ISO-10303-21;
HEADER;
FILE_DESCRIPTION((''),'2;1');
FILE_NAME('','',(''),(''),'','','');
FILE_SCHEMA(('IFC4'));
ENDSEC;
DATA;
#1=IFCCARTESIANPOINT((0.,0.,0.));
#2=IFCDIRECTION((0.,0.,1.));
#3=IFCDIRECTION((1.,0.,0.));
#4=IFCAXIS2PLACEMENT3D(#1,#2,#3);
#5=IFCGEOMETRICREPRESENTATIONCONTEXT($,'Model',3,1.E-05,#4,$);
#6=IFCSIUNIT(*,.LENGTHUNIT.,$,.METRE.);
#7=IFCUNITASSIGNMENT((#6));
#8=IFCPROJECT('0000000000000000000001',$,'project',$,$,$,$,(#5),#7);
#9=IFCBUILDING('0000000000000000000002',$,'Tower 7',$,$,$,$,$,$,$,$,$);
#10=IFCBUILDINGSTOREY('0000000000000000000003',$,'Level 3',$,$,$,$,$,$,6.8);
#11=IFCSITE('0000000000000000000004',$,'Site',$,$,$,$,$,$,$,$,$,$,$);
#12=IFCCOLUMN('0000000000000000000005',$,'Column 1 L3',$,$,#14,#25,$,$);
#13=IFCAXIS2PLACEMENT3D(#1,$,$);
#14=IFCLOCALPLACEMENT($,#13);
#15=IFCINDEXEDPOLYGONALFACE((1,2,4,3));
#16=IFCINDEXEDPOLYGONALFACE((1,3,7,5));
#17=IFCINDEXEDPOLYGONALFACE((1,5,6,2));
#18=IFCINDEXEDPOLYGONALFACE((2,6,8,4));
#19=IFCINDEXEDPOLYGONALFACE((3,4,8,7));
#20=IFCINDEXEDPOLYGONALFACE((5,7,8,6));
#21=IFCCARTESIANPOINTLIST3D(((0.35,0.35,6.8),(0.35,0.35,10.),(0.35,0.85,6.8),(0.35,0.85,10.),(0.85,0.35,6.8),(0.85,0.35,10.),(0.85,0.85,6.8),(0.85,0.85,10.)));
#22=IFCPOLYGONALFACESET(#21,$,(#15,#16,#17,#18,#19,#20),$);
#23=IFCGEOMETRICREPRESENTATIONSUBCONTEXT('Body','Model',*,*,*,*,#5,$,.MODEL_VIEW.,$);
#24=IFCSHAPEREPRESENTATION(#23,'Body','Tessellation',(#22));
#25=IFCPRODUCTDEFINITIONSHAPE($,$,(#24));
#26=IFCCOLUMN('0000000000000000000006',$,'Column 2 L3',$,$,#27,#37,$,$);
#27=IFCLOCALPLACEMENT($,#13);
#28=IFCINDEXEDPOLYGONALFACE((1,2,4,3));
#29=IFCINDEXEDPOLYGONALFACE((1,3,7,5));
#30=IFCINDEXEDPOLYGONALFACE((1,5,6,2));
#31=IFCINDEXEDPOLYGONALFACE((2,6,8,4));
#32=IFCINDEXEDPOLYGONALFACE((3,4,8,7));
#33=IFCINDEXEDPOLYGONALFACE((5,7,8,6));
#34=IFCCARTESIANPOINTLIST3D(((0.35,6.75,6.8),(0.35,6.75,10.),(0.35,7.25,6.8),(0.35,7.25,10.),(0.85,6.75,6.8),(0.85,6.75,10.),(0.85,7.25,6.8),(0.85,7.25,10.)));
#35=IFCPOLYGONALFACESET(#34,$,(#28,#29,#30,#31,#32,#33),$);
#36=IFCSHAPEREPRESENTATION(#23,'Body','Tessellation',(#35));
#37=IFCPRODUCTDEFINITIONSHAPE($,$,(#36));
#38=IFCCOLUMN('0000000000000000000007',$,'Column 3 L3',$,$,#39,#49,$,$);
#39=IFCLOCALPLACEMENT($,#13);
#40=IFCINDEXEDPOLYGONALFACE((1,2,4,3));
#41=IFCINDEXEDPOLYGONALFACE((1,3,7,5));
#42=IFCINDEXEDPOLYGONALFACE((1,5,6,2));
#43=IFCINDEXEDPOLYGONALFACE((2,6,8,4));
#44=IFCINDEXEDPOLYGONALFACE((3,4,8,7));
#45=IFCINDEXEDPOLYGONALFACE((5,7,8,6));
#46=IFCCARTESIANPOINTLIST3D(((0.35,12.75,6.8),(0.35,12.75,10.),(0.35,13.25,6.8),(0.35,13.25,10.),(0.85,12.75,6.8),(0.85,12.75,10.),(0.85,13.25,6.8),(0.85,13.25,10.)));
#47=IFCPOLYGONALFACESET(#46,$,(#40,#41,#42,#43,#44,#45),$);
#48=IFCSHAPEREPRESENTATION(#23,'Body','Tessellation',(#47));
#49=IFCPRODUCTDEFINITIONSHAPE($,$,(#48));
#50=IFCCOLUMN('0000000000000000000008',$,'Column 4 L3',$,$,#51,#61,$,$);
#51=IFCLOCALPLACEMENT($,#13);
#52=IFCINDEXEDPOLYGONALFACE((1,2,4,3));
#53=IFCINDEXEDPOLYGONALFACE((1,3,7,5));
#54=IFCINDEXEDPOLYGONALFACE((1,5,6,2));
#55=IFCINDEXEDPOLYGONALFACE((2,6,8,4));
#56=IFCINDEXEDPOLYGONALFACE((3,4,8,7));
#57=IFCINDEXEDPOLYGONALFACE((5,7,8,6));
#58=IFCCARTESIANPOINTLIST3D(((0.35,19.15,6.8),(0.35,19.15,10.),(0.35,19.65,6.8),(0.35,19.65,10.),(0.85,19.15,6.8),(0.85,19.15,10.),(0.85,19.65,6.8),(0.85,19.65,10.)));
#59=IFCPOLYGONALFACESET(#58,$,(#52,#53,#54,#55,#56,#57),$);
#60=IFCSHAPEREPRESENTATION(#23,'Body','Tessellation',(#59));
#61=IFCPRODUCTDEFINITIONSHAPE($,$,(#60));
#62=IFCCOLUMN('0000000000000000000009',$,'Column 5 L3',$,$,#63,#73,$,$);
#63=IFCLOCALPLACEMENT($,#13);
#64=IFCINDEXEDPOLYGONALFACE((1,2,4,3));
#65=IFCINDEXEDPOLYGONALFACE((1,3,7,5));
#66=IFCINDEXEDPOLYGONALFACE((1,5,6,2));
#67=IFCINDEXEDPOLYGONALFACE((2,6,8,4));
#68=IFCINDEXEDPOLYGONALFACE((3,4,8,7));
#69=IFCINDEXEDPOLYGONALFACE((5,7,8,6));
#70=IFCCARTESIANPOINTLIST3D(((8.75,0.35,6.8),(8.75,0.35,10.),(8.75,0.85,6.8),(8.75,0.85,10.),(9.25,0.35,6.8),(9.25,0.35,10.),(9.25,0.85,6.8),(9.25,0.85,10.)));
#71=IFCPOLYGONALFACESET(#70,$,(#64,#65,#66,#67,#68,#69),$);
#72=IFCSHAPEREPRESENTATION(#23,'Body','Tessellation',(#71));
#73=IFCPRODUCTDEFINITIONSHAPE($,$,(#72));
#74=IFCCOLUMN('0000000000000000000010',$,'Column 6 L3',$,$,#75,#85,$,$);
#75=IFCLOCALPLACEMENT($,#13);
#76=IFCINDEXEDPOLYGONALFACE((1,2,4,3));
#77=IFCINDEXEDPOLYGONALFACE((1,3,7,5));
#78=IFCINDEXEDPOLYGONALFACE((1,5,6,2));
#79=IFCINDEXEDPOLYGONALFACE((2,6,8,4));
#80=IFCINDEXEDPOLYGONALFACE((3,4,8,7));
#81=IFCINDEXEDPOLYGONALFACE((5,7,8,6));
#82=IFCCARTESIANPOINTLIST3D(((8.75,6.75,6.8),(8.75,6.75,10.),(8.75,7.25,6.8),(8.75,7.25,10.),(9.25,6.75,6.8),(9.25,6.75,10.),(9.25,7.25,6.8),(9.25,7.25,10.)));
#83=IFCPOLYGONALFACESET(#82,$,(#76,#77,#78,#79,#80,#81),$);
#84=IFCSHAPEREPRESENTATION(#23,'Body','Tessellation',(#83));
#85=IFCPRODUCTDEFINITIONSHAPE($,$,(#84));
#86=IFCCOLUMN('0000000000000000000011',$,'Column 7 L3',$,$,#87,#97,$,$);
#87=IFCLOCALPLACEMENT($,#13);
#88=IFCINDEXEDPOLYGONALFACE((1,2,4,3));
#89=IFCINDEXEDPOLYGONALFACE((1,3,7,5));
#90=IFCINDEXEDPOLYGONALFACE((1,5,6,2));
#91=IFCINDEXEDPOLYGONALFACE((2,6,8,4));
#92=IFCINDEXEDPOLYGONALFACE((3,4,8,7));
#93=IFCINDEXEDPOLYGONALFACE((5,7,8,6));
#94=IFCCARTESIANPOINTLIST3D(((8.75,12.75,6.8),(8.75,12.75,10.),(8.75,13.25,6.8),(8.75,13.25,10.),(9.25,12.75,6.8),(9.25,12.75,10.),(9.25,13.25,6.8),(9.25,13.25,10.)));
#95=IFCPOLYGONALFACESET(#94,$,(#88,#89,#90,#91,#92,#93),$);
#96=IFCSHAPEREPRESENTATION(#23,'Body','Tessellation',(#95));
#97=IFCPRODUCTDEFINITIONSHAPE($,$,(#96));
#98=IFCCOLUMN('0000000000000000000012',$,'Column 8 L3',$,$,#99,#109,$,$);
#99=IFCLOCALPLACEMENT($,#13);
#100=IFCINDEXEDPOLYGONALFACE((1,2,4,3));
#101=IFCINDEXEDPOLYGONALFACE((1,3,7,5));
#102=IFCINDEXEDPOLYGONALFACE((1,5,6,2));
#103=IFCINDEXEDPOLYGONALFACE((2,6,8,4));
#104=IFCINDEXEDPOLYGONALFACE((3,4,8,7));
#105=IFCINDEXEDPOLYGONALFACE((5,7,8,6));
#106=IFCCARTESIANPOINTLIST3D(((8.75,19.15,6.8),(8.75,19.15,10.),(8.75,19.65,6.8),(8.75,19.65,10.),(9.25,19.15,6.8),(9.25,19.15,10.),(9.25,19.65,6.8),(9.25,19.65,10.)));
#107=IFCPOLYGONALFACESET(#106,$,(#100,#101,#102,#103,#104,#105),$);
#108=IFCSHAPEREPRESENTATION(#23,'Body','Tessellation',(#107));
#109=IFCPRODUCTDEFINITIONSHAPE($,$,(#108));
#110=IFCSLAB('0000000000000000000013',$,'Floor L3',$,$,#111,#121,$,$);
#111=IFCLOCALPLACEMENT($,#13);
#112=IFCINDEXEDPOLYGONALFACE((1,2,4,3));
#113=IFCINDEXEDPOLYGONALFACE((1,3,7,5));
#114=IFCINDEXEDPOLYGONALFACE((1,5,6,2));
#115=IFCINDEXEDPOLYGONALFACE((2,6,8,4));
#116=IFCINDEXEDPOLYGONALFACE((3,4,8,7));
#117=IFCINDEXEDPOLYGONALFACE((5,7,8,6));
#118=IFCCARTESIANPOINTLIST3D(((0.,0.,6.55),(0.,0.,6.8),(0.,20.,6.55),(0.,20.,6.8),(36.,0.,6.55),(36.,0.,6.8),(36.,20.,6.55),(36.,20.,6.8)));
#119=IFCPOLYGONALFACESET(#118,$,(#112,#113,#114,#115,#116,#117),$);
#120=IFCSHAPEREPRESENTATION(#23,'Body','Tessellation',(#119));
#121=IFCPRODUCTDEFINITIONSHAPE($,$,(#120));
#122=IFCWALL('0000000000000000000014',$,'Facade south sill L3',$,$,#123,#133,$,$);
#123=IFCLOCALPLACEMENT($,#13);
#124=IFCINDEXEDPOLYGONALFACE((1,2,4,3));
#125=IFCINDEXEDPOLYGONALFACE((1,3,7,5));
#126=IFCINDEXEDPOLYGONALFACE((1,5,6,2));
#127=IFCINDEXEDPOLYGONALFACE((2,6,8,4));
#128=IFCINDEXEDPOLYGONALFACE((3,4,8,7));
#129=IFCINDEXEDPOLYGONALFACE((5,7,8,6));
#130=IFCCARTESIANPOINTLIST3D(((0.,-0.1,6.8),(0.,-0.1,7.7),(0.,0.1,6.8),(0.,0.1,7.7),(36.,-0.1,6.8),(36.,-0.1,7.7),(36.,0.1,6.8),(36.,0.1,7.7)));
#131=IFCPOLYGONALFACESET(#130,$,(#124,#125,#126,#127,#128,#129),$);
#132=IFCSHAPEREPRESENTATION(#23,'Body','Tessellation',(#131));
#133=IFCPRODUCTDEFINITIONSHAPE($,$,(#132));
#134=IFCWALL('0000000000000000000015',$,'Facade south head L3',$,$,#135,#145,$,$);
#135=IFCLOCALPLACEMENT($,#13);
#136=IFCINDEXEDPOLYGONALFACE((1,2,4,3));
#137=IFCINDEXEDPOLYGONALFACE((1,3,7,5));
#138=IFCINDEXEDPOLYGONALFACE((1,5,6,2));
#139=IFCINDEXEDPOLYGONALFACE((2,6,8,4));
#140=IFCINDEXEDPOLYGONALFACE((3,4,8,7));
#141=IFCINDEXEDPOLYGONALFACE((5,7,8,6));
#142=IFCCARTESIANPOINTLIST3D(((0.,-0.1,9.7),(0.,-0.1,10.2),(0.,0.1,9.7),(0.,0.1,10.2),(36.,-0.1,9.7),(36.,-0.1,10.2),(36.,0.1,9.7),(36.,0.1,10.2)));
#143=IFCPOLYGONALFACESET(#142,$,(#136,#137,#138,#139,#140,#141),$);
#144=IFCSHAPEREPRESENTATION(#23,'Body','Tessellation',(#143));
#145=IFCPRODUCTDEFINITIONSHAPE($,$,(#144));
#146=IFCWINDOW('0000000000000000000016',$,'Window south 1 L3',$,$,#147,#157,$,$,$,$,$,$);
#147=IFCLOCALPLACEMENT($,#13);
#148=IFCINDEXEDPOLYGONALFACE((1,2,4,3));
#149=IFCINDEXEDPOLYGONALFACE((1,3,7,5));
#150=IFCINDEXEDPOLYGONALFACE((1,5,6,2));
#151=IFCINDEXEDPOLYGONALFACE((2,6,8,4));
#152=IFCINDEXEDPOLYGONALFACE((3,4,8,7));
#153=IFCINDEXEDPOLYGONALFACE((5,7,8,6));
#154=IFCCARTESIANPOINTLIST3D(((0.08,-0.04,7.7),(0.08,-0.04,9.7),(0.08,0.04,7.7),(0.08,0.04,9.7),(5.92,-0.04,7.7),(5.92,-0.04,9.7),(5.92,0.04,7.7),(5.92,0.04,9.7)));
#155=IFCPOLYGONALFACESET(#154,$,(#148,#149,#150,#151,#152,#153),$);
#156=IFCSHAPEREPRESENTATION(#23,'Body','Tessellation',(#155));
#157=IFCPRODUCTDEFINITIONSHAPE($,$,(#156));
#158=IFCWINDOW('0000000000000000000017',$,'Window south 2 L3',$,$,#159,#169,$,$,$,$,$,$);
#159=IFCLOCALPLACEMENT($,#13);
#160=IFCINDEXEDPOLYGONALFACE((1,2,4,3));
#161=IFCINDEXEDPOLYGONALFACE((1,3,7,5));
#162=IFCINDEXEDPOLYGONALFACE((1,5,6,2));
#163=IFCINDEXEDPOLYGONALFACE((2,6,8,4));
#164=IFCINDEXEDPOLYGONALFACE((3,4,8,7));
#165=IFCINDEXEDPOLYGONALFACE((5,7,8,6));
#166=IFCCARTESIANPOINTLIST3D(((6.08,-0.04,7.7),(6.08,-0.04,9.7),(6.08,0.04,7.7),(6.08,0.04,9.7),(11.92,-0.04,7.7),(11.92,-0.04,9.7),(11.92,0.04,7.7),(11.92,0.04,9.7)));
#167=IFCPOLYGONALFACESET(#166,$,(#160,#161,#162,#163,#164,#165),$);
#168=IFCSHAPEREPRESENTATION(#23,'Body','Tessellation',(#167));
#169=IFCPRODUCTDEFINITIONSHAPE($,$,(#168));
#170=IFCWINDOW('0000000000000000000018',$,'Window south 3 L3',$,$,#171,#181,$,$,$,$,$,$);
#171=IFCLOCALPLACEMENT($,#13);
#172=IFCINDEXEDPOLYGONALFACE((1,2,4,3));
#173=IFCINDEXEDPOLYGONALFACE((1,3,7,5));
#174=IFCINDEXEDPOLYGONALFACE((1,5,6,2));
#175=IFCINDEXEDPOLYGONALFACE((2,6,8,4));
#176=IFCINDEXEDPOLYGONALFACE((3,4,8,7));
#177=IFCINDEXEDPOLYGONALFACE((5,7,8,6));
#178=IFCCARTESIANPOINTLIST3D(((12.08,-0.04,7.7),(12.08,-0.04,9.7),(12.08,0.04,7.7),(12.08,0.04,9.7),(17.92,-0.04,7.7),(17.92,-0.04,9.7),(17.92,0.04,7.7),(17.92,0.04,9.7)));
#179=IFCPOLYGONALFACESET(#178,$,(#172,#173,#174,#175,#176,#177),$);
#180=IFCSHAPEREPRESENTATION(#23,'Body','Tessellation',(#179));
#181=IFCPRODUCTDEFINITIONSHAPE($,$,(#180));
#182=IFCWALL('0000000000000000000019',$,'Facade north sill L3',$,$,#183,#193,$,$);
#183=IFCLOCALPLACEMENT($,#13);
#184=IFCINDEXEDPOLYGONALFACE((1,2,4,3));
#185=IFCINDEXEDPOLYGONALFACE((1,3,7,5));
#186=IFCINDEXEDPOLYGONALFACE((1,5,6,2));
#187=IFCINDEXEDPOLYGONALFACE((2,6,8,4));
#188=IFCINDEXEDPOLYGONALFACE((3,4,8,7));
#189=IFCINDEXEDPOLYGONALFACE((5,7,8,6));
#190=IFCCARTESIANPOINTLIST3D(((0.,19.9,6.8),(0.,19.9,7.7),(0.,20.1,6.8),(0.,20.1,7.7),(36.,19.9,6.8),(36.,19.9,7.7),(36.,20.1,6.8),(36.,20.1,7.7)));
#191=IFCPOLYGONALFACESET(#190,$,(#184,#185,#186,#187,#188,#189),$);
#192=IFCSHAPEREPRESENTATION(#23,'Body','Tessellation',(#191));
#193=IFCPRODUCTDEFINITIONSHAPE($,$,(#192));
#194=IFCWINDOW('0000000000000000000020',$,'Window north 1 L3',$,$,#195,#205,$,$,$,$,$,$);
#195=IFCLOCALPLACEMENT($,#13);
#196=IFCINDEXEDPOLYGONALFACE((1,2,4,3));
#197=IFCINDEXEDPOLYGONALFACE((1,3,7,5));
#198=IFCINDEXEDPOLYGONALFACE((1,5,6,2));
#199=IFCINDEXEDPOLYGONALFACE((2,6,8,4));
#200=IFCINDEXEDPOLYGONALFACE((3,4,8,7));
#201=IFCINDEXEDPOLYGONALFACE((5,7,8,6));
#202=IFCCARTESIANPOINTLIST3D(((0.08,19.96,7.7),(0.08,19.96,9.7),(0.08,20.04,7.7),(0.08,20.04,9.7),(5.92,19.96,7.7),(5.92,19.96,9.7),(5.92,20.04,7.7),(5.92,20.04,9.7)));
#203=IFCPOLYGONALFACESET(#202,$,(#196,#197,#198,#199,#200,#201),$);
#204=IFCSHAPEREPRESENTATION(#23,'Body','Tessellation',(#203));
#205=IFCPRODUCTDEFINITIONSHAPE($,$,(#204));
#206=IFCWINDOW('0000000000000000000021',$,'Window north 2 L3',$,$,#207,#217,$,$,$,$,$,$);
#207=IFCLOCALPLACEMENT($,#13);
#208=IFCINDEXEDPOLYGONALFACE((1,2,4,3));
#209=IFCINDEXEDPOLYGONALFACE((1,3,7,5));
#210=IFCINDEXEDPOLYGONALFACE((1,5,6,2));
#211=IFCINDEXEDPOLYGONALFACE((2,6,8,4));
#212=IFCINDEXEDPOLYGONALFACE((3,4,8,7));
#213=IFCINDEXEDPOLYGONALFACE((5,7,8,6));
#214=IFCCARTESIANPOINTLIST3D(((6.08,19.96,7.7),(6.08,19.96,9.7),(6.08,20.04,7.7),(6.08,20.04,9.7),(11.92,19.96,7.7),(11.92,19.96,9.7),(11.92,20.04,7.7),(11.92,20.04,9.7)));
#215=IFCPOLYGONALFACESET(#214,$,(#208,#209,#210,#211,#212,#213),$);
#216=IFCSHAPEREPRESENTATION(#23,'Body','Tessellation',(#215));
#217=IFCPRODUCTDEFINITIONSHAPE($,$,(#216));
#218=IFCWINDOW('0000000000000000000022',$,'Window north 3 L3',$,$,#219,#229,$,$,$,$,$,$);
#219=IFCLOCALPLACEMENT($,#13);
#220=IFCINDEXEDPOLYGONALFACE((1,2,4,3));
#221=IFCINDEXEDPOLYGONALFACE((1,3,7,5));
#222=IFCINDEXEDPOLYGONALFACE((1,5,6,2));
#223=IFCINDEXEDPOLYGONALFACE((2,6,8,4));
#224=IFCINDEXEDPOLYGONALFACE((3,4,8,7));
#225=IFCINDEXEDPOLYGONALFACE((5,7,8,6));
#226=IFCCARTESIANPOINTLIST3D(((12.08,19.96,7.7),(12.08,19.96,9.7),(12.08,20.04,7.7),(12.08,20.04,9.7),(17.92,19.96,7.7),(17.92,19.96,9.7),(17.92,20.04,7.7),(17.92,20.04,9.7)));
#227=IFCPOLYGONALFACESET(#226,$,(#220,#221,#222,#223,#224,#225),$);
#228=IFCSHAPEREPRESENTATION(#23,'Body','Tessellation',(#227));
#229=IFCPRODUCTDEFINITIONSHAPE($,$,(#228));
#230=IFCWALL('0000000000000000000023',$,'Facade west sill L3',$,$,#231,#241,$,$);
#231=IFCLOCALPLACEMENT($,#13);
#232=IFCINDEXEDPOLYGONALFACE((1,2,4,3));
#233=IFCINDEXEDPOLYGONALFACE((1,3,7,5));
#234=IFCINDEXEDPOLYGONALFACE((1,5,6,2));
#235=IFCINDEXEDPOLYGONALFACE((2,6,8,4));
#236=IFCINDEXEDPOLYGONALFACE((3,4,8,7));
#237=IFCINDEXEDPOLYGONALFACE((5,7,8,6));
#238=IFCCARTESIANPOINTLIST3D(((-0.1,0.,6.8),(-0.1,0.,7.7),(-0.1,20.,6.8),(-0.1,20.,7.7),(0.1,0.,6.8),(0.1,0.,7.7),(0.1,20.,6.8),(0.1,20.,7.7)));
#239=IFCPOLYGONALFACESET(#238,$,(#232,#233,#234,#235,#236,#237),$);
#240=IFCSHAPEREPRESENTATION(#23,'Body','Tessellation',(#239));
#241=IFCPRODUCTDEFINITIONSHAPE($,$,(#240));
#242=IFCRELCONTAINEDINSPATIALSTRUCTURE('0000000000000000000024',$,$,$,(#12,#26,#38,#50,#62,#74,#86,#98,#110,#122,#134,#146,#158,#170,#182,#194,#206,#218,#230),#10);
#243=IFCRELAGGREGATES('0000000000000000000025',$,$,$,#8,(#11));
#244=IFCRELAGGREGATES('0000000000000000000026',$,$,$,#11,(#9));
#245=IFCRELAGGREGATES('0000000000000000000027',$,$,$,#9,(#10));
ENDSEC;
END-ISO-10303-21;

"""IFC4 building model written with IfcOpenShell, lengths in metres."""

from ifc_helpers import new_model, si_unit, frame, origin, origin_with_axes, origin_2d, place, context, subcontext, project, spatial, rectangle, extrude, element, save


model = new_model("IFC4")

# Units and contexts
model_context = context("Model", 3, precision=1e-05, world=origin_with_axes())
body_context = subcontext(model_context, "Body", "Model", "MODEL_VIEW")
ifc_project = project(units=[si_unit("LENGTHUNIT", "METRE")], contexts=[model_context])

# Site, building, storey
site = spatial("IfcSite", under=ifc_project, Name="Site")
building = spatial("IfcBuilding", under=site, Name="Tower 7")
storey = spatial("IfcBuildingStorey", under=building, Name="Level 3", Elevation=6.8)

# Columns
for number, where, z_axis, x_axis, name in (
    (1, (0.6, 0.6, 6.8), (0.0, 0.0, 1.0), (1.0, 0.0, 0.0), "Column 1 L3"),
    (2, (0.6, 7.0, 6.8), (0.0, 0.0, 1.0), (1.0, 0.0, 0.0), "Column 2 L3"),
    (3, (0.6, 13.0, 6.8), (0.0, 0.0, 1.0), (1.0, 0.0, 0.0), "Column 3 L3"),
    (4, (0.6, 19.4, 6.8), (0.0, 0.0, 1.0), (1.0, 0.0, 0.0), "Column 4 L3"),
    (5, (9.0, 0.6, 6.8), (0.0, 0.0, 1.0), (1.0, 0.0, 0.0), "Column 5 L3"),
    (6, (9.0, 7.0, 6.8), (0.0, 0.0, 1.0), (1.0, 0.0, 0.0), "Column 6 L3"),
    (7, (9.0, 13.0, 6.8), (0.0, 0.0, 1.0), (1.0, 0.0, 0.0), "Column 7 L3"),
    (8, (9.0, 19.4, 6.8), (0.0, 0.0, 1.0), (1.0, 0.0, 0.0), "Column 8 L3"),
):
    element("IfcColumn", number, at=place(None, frame(where, z_axis=z_axis, x_axis=x_axis)), inside=storey, Name=name, context=body_context, shape_type="SweptSolid", body=[
        extrude(rectangle(XDim=0.5, YDim=0.5, at=origin_2d()), origin(), (0.0, 0.0, 1.0), 3.2),
    ])

# Slab
slab_placement = place(None, frame((18.0, 10.0, 6.55), z_axis=(0.0, 0.0, 1.0), x_axis=(1.0, 0.0, 0.0)))
element("IfcSlab", 9, at=slab_placement, inside=storey, Name="Floor L3", context=body_context, shape_type="SweptSolid", body=[
    extrude(rectangle(XDim=36.0, YDim=20.0, at=origin_2d()), origin(), (0.0, 0.0, 1.0), 0.25),
])

# Walls
wall_1_placement = place(None, frame((18.0, 0.0, 6.8), z_axis=(0.0, 0.0, 1.0), x_axis=(1.0, 0.0, 0.0)))
element("IfcWall", 10, at=wall_1_placement, inside=storey, Name="Facade south sill L3", context=body_context, shape_type="SweptSolid", body=[
    extrude(rectangle(XDim=36.0, YDim=0.2, at=origin_2d()), origin(), (0.0, 0.0, 1.0), 0.9),
])
wall_2_placement = place(None, frame((18.0, 0.0, 9.7), z_axis=(0.0, 0.0, 1.0), x_axis=(1.0, 0.0, 0.0)))
element("IfcWall", 11, at=wall_2_placement, inside=storey, Name="Facade south head L3", context=body_context, shape_type="SweptSolid", body=[
    extrude(rectangle(XDim=36.0, YDim=0.2, at=origin_2d()), origin(), (0.0, 0.0, 1.0), 0.5),
])

# Windows
for number, where, z_axis, x_axis, name in (
    (12, (3.0, 0.0, 7.7), (0.0, 0.0, 1.0), (1.0, 0.0, 0.0), "Window south 1 L3"),
    (13, (9.0, 0.0, 7.7), (0.0, 0.0, 1.0), (1.0, 0.0, 0.0), "Window south 2 L3"),
):
    element("IfcWindow", number, at=place(None, frame(where, z_axis=z_axis, x_axis=x_axis)), inside=storey, Name=name, context=body_context, shape_type="SweptSolid", body=[
        extrude(rectangle(XDim=5.84, YDim=0.08, at=origin_2d()), origin(), (0.0, 0.0, 1.0), 2.0),
    ])
window_1_placement = place(None, frame((15.0, 0.0, 7.7), z_axis=(0.0, 0.0, 1.0), x_axis=(1.0, 0.0, 0.0)))
element("IfcWindow", 14, at=window_1_placement, inside=storey, Name="Window south 3 L3", context=body_context, shape_type="SweptSolid", body=[
    extrude(rectangle(XDim=5.84, YDim=0.08, at=origin_2d()), origin(), (0.0, 0.0, 1.0), 2.0),
])

# Wall
wall_3_placement = place(None, frame((18.0, 20.0, 6.8), z_axis=(0.0, 0.0, 1.0), x_axis=(1.0, 0.0, 0.0)))
element("IfcWall", 15, at=wall_3_placement, inside=storey, Name="Facade north sill L3", context=body_context, shape_type="SweptSolid", body=[
    extrude(rectangle(XDim=36.0, YDim=0.2, at=origin_2d()), origin(), (0.0, 0.0, 1.0), 0.9),
])

# Windows
for number, where, z_axis, x_axis, name in (
    (16, (3.0, 20.0, 7.7), (0.0, 0.0, 1.0), (1.0, 0.0, 0.0), "Window north 1 L3"),
    (17, (9.0, 20.0, 7.7), (0.0, 0.0, 1.0), (1.0, 0.0, 0.0), "Window north 2 L3"),
):
    element("IfcWindow", number, at=place(None, frame(where, z_axis=z_axis, x_axis=x_axis)), inside=storey, Name=name, context=body_context, shape_type="SweptSolid", body=[
        extrude(rectangle(XDim=5.84, YDim=0.08, at=origin_2d()), origin(), (0.0, 0.0, 1.0), 2.0),
    ])
window_2_placement = place(None, frame((15.0, 20.0, 7.7), z_axis=(0.0, 0.0, 1.0), x_axis=(1.0, 0.0, 0.0)))
element("IfcWindow", 18, at=window_2_placement, inside=storey, Name="Window north 3 L3", context=body_context, shape_type="SweptSolid", body=[
    extrude(rectangle(XDim=5.84, YDim=0.08, at=origin_2d()), origin(), (0.0, 0.0, 1.0), 2.0),
])

# Wall
wall_4_placement = place(None, frame((0.0, 10.0, 6.8), z_axis=(0.0, 0.0, 1.0), x_axis=(1.0, 0.0, 0.0)))
element("IfcWall", 19, at=wall_4_placement, inside=storey, Name="Facade west sill L3", context=body_context, shape_type="SweptSolid", body=[
    extrude(rectangle(XDim=0.2, YDim=20.0, at=origin_2d()), origin(), (0.0, 0.0, 1.0), 0.9),
])

save(model, "model.ifc")
